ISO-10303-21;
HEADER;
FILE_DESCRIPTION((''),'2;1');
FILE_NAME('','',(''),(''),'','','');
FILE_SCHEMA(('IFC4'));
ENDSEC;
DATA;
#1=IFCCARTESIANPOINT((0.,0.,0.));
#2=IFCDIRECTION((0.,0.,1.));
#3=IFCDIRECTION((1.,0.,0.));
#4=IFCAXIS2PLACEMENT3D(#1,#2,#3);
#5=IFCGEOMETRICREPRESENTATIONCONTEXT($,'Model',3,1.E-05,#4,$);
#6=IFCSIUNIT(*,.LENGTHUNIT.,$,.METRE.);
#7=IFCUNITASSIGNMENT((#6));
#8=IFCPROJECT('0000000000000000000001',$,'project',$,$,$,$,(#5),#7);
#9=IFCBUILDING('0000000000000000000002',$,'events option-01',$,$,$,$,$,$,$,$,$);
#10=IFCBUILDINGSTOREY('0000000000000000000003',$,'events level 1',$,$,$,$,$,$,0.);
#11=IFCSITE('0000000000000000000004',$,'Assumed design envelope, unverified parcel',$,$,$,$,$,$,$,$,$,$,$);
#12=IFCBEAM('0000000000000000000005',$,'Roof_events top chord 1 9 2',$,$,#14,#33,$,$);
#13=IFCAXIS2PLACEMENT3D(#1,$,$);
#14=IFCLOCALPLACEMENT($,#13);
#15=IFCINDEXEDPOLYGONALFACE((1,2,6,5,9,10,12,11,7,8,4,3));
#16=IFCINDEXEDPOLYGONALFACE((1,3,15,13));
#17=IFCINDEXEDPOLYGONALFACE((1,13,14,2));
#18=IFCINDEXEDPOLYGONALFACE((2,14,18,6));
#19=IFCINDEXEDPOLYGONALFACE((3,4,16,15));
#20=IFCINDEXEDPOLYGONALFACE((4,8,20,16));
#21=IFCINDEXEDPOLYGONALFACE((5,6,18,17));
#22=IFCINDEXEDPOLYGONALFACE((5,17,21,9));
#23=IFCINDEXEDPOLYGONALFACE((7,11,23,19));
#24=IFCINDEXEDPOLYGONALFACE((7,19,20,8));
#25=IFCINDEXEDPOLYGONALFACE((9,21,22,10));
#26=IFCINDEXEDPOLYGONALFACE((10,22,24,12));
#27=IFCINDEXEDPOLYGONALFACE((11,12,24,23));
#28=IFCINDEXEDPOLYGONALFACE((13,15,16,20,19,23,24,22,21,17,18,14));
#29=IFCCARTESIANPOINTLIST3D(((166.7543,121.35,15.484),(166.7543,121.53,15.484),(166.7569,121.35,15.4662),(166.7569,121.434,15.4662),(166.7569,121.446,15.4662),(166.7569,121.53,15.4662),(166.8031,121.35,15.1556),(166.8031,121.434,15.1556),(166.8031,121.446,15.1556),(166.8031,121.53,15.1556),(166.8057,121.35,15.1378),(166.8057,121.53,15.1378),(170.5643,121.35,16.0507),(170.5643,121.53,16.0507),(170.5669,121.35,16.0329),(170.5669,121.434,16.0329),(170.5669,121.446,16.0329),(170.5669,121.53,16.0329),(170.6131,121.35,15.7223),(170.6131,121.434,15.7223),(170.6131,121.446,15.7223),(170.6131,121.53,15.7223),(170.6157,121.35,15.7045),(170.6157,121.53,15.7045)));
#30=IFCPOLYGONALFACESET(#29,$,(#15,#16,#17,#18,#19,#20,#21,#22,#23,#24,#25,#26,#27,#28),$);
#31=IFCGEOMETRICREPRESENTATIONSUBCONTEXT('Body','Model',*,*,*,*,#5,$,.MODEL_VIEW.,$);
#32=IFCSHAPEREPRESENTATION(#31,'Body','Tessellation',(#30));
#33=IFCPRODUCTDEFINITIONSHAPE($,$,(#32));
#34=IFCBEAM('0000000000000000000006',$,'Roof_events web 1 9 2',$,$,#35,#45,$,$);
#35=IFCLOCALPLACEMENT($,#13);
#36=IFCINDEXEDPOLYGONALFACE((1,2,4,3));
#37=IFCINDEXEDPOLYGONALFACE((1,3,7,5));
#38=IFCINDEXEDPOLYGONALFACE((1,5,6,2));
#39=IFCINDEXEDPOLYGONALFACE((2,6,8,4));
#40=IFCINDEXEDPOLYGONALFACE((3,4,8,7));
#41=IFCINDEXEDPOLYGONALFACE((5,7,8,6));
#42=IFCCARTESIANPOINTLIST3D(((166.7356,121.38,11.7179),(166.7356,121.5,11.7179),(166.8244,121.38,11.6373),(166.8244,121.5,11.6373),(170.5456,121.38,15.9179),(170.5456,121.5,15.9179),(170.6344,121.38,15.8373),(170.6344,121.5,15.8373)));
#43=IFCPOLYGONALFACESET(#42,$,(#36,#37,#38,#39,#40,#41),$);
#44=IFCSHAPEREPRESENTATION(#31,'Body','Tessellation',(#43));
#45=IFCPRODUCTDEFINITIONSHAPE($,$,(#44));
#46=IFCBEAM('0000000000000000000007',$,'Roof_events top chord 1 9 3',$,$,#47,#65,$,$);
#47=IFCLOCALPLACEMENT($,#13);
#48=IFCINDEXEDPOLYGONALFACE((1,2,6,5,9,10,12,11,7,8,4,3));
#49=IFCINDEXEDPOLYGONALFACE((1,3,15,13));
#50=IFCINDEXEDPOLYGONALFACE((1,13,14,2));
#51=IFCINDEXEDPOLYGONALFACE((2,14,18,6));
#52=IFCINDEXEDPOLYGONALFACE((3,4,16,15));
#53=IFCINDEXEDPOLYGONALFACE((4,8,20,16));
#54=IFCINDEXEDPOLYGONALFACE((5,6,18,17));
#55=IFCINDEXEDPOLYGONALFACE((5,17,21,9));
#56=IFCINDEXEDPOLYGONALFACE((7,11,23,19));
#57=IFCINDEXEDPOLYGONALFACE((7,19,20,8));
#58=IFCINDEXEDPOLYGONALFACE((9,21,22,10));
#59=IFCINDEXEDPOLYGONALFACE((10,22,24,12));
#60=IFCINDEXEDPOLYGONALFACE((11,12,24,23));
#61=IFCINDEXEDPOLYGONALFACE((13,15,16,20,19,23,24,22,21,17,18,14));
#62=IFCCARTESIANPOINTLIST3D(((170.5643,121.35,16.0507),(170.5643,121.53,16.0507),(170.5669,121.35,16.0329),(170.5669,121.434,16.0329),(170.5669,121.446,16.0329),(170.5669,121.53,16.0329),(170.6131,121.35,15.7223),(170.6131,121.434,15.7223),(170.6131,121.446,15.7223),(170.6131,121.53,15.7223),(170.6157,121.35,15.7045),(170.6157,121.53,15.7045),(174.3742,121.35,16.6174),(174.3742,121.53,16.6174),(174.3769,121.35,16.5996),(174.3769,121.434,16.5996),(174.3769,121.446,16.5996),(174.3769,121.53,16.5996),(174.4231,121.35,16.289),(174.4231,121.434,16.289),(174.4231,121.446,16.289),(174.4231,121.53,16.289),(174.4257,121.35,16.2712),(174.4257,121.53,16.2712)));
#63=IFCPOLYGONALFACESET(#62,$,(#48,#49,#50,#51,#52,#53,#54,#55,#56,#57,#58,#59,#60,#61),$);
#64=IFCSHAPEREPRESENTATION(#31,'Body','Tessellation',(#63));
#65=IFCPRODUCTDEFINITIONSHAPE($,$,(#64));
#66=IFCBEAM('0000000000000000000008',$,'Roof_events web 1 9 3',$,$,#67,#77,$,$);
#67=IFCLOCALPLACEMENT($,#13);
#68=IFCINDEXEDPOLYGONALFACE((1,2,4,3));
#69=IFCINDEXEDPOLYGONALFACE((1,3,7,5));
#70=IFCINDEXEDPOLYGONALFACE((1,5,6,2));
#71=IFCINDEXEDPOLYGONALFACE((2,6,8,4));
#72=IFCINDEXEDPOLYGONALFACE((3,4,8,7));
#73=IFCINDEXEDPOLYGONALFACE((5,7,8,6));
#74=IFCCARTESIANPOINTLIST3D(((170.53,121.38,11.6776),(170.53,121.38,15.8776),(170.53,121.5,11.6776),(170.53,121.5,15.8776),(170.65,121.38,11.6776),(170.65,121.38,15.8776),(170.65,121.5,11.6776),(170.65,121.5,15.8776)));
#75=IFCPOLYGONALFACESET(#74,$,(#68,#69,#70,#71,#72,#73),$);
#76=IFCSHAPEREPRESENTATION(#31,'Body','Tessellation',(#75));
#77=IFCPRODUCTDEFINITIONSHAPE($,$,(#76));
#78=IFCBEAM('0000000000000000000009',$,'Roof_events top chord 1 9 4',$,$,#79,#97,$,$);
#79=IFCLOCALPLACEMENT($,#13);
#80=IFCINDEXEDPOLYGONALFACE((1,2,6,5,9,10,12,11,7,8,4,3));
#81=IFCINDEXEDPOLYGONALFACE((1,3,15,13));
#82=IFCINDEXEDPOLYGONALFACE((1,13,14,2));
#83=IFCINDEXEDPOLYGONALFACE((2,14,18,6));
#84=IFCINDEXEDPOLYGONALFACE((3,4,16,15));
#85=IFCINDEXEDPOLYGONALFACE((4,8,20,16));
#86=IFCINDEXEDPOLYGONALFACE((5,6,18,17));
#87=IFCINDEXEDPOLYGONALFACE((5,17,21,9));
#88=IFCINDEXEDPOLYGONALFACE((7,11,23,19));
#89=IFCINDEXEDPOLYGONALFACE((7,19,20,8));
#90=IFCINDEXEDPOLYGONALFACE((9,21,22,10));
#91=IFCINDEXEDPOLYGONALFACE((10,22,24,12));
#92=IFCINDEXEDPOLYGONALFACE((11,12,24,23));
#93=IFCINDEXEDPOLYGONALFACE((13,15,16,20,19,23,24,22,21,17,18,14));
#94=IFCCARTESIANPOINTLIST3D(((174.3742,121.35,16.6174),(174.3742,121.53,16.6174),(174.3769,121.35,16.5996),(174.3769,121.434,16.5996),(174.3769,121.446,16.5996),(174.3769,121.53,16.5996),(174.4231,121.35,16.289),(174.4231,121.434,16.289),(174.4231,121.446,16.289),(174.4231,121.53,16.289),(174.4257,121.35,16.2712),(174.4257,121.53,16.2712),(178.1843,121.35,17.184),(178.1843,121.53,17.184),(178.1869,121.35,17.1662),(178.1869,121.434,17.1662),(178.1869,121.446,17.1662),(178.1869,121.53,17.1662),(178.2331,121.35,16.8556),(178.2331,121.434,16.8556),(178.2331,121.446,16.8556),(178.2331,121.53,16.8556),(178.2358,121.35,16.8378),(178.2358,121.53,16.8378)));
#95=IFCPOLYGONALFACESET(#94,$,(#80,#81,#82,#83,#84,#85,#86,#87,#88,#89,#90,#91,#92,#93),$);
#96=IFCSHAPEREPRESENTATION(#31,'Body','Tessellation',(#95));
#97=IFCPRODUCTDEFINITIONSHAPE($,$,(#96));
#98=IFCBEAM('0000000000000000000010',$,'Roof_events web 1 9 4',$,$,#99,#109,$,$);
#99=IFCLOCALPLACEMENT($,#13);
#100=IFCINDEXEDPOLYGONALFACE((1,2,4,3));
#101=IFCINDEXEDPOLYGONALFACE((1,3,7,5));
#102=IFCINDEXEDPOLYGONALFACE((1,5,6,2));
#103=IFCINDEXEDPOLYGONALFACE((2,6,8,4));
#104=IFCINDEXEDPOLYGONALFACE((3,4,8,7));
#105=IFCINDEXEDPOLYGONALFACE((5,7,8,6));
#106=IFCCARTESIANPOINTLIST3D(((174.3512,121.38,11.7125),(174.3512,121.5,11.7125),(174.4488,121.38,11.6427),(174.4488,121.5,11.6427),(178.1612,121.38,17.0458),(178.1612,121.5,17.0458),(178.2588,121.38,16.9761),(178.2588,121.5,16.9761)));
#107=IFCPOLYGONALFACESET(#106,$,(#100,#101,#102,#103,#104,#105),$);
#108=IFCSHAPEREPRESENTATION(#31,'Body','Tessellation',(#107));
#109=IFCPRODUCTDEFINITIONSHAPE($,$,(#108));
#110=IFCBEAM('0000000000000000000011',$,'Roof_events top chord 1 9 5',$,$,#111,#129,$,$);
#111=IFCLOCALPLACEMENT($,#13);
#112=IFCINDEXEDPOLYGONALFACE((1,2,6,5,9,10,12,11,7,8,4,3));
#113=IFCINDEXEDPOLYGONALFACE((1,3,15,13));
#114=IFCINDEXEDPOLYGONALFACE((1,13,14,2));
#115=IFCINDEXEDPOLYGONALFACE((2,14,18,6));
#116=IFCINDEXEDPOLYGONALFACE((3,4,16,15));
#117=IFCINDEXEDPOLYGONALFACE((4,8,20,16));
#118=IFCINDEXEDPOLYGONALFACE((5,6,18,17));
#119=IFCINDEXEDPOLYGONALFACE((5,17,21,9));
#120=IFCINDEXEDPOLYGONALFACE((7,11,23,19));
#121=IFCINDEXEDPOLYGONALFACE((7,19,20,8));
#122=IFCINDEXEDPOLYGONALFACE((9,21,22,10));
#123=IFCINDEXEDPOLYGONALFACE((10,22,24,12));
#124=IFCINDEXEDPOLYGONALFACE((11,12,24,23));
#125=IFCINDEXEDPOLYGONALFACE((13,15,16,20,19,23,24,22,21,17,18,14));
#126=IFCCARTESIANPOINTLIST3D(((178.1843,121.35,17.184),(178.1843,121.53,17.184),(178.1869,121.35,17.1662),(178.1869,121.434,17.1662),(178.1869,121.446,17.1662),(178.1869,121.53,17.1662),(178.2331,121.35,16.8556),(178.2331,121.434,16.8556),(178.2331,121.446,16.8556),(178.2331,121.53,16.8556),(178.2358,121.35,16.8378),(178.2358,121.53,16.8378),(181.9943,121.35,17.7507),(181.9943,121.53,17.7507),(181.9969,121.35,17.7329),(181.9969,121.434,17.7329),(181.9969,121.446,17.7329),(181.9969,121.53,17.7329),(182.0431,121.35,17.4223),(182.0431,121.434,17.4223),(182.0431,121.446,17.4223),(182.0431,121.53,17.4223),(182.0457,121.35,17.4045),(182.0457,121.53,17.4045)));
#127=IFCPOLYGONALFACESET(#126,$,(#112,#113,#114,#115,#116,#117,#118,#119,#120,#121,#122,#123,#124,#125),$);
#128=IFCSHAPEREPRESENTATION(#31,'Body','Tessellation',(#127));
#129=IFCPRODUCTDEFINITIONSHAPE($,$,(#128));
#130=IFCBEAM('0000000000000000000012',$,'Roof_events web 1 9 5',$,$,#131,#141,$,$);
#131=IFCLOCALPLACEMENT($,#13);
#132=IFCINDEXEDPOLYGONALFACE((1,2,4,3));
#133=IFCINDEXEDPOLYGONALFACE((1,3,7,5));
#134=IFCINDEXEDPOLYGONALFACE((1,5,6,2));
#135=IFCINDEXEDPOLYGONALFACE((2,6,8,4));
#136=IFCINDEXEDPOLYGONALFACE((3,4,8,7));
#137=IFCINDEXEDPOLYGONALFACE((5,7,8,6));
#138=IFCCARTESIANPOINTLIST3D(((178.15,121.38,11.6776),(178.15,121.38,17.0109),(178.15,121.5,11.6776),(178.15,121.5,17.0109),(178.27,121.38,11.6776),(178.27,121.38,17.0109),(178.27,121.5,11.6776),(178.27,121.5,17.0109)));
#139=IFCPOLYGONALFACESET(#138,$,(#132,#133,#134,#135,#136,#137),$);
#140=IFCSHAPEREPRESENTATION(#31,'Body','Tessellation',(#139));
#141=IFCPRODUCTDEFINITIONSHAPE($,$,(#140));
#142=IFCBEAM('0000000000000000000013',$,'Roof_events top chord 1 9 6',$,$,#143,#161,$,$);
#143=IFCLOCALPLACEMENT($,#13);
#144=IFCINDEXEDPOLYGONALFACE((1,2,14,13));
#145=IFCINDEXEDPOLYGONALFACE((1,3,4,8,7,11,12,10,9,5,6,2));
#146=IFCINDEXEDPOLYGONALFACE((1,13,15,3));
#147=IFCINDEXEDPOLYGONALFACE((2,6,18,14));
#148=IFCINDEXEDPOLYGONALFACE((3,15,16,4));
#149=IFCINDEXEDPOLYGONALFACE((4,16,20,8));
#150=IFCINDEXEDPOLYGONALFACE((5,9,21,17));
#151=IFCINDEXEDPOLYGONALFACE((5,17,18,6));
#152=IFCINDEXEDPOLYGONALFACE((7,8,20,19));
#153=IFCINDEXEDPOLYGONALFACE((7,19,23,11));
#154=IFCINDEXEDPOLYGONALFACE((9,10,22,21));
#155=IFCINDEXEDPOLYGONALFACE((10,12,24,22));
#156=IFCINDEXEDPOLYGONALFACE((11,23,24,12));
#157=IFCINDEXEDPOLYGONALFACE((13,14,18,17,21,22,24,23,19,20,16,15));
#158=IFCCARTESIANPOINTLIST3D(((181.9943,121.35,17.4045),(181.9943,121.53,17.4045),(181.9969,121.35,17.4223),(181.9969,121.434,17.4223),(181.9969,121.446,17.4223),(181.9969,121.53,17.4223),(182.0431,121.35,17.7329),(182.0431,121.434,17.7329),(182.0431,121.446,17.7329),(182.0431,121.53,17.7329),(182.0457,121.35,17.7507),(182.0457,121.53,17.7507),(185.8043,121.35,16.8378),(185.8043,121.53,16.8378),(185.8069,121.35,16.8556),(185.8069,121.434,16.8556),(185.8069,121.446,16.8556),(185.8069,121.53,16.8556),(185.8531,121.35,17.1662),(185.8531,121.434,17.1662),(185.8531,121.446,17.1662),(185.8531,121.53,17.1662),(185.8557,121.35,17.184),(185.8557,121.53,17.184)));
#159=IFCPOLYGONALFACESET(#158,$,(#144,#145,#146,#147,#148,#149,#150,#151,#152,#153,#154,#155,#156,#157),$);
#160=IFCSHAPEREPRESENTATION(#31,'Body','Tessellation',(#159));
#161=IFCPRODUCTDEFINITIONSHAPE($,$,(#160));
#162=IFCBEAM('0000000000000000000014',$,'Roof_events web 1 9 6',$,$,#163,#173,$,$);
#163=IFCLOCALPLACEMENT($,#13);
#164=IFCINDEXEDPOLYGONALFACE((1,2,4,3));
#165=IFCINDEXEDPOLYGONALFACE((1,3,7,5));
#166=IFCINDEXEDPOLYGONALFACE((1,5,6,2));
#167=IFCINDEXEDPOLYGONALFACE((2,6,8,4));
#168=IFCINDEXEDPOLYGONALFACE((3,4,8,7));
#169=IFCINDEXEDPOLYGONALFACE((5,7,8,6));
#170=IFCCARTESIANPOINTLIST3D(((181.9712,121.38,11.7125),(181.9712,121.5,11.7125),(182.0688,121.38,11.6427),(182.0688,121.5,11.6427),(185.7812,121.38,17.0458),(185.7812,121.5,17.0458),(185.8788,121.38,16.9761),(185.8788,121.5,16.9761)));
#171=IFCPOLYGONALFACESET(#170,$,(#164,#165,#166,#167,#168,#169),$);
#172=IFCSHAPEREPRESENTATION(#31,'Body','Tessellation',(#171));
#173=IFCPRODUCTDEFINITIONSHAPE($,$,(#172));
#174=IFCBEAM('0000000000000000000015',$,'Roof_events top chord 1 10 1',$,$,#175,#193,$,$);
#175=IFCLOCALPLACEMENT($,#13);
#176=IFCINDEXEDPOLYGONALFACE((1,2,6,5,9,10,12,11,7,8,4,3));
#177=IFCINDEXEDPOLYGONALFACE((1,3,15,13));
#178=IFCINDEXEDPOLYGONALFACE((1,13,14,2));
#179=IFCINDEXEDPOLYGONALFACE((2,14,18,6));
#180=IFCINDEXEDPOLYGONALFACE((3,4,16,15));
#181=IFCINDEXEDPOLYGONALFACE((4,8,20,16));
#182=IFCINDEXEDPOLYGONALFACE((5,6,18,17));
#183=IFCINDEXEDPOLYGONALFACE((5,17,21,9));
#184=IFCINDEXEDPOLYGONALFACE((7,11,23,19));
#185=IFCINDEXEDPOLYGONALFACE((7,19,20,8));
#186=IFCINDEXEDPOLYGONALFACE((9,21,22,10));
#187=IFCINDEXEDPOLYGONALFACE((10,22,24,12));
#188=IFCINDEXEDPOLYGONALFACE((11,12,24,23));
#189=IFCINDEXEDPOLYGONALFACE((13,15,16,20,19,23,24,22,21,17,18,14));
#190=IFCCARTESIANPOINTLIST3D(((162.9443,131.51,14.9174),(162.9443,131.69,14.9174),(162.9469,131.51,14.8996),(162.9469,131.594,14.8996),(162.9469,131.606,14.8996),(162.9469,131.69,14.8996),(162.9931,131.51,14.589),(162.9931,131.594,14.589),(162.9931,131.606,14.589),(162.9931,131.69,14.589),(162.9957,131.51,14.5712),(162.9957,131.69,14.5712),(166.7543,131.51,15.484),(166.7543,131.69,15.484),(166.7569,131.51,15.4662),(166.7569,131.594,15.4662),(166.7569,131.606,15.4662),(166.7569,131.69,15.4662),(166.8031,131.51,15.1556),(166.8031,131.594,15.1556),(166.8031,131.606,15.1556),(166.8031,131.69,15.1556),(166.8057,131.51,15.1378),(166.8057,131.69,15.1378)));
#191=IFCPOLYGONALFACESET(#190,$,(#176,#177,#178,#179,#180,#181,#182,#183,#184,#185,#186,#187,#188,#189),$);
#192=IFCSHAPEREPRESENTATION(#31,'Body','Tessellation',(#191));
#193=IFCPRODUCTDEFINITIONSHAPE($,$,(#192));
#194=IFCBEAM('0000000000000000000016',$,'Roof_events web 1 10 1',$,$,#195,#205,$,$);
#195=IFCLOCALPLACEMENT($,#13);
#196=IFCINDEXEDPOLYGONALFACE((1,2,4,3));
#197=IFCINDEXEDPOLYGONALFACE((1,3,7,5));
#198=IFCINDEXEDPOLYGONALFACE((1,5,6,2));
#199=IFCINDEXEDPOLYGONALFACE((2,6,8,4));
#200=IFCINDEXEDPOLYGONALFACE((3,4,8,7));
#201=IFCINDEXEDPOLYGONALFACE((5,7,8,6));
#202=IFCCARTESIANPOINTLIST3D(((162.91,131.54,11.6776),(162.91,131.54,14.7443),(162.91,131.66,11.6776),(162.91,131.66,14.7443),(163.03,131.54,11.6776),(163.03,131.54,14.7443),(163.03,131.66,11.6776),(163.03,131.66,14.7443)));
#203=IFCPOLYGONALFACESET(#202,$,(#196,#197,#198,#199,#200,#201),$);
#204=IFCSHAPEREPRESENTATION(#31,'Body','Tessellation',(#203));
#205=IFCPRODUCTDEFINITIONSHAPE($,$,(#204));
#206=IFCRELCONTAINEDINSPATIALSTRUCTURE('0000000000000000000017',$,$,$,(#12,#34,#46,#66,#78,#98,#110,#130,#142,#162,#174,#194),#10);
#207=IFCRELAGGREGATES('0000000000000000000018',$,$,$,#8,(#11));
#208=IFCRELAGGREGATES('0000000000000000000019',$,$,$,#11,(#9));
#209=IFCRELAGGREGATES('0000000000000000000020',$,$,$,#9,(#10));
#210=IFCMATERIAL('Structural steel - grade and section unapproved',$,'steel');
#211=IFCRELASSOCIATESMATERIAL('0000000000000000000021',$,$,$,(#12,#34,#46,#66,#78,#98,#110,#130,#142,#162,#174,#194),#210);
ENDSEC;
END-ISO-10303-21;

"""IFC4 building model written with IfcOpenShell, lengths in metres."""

from ifc_helpers import new_model, si_unit, frame, origin_with_axes, place, context, subcontext, project, spatial, rectangle, i_section, extrude, material, element, save


model = new_model("IFC4")

# Units and contexts
model_context = context("Model", 3, precision=1e-05, world=origin_with_axes())
body_context = subcontext(model_context, "Body", "Model", "MODEL_VIEW")
ifc_project = project(units=[si_unit("LENGTHUNIT", "METRE")], contexts=[model_context])

# Site, building, storey
site = spatial("IfcSite", under=ifc_project, Name="Assumed design envelope, unverified parcel")
building = spatial("IfcBuilding", under=site, Name="events option-01")
storey = spatial("IfcBuildingStorey", under=building, Name="events level 1", Elevation=0.0)

# Beams
ifc_material_1 = material(Name="Structural steel - grade and section unapproved", Category="steel")
beam_1_placement = place(None, frame((166.78, 121.44, 15.3109), z_axis=(0.98912, 0.0, 0.147113), x_axis=(0.0, 1.0, 0.0)))
element("IfcBeam", 1, at=beam_1_placement, inside=storey, material=ifc_material_1, Name="Roof_events top chord 1 9 2", context=body_context, shape_type="SweptSolid", body=[
    extrude(i_section(OverallWidth=0.18, OverallDepth=0.35, WebThickness=0.012, FlangeThickness=0.018, FilletRadius=0.0), origin_with_axes(), (0.0, 0.0, 1.0), 3.8519),
])
beam_2_placement = place(None, frame((166.78, 121.44, 11.6776), z_axis=(0.671882, 0.0, 0.740658), x_axis=(0.0, 1.0, 0.0)))
element("IfcBeam", 2, at=beam_2_placement, inside=storey, material=ifc_material_1, Name="Roof_events web 1 9 2", context=body_context, shape_type="SweptSolid", body=[
    extrude(rectangle(XDim=0.12, YDim=0.12), origin_with_axes(), (0.0, 0.0, 1.0), 5.6706),
])
beam_3_placement = place(None, frame((170.59, 121.44, 15.8776), z_axis=(0.98912, 0.0, 0.147113), x_axis=(0.0, 1.0, 0.0)))
element("IfcBeam", 3, at=beam_3_placement, inside=storey, material=ifc_material_1, Name="Roof_events top chord 1 9 3", context=body_context, shape_type="SweptSolid", body=[
    extrude(i_section(OverallWidth=0.18, OverallDepth=0.35, WebThickness=0.012, FlangeThickness=0.018, FilletRadius=0.0), origin_with_axes(), (0.0, 0.0, 1.0), 3.8519),
])
beam_4_placement = place(None, frame((170.59, 121.44, 11.6776), z_axis=(0.0, 0.0, 1.0), x_axis=(-1.0, 0.0, 0.0)))
element("IfcBeam", 4, at=beam_4_placement, inside=storey, material=ifc_material_1, Name="Roof_events web 1 9 3", context=body_context, shape_type="SweptSolid", body=[
    extrude(rectangle(XDim=0.12, YDim=0.12), origin_with_axes(), (0.0, 0.0, 1.0), 4.2),
])
beam_5_placement = place(None, frame((174.4, 121.44, 16.4443), z_axis=(0.98912, 0.0, 0.147112), x_axis=(0.0, 1.0, 0.0)))
element("IfcBeam", 5, at=beam_5_placement, inside=storey, material=ifc_material_1, Name="Roof_events top chord 1 9 4", context=body_context, shape_type="SweptSolid", body=[
    extrude(i_section(OverallWidth=0.18, OverallDepth=0.35, WebThickness=0.012, FlangeThickness=0.018, FilletRadius=0.0), origin_with_axes(), (0.0, 0.0, 1.0), 3.8519),
])
beam_6_placement = place(None, frame((174.4, 121.44, 11.6776), z_axis=(0.581288, 0.0, 0.813698), x_axis=(0.0, 1.0, 0.0)))
element("IfcBeam", 6, at=beam_6_placement, inside=storey, material=ifc_material_1, Name="Roof_events web 1 9 4", context=body_context, shape_type="SweptSolid", body=[
    extrude(rectangle(XDim=0.12, YDim=0.12), origin_with_axes(), (0.0, 0.0, 1.0), 6.5544),
])
beam_7_placement = place(None, frame((178.21, 121.44, 17.0109), z_axis=(0.98912, 0.0, 0.147113), x_axis=(0.0, 1.0, 0.0)))
element("IfcBeam", 7, at=beam_7_placement, inside=storey, material=ifc_material_1, Name="Roof_events top chord 1 9 5", context=body_context, shape_type="SweptSolid", body=[
    extrude(i_section(OverallWidth=0.18, OverallDepth=0.35, WebThickness=0.012, FlangeThickness=0.018, FilletRadius=0.0), origin_with_axes(), (0.0, 0.0, 1.0), 3.8519),
])
beam_8_placement = place(None, frame((178.21, 121.44, 11.6776), z_axis=(0.0, 0.0, 1.0), x_axis=(-1.0, 0.0, 0.0)))
element("IfcBeam", 8, at=beam_8_placement, inside=storey, material=ifc_material_1, Name="Roof_events web 1 9 5", context=body_context, shape_type="SweptSolid", body=[
    extrude(rectangle(XDim=0.12, YDim=0.12), origin_with_axes(), (0.0, 0.0, 1.0), 5.3333),
])
beam_9_placement = place(None, frame((182.02, 121.44, 17.5776), z_axis=(0.98912, 0.0, -0.147113), x_axis=(0.0, 1.0, 0.0)))
element("IfcBeam", 9, at=beam_9_placement, inside=storey, material=ifc_material_1, Name="Roof_events top chord 1 9 6", context=body_context, shape_type="SweptSolid", body=[
    extrude(i_section(OverallWidth=0.18, OverallDepth=0.35, WebThickness=0.012, FlangeThickness=0.018, FilletRadius=0.0), origin_with_axes(), (0.0, 0.0, 1.0), 3.8519),
])
beam_10_placement = place(None, frame((182.02, 121.44, 11.6776), z_axis=(0.581286, 0.0, 0.813699), x_axis=(0.0, 1.0, 0.0)))
element("IfcBeam", 10, at=beam_10_placement, inside=storey, material=ifc_material_1, Name="Roof_events web 1 9 6", context=body_context, shape_type="SweptSolid", body=[
    extrude(rectangle(XDim=0.12, YDim=0.12), origin_with_axes(), (0.0, 0.0, 1.0), 6.5544),
])
beam_11_placement = place(None, frame((162.97, 131.6, 14.7443), z_axis=(0.98912, 0.0, 0.147113), x_axis=(0.0, 1.0, 0.0)))
element("IfcBeam", 11, at=beam_11_placement, inside=storey, material=ifc_material_1, Name="Roof_events top chord 1 10 1", context=body_context, shape_type="SweptSolid", body=[
    extrude(i_section(OverallWidth=0.18, OverallDepth=0.35, WebThickness=0.012, FlangeThickness=0.018, FilletRadius=0.0), origin_with_axes(), (0.0, 0.0, 1.0), 3.8519),
])
beam_12_placement = place(None, frame((162.97, 131.6, 11.6776), z_axis=(0.0, 0.0, 1.0), x_axis=(-1.0, 0.0, 0.0)))
element("IfcBeam", 12, at=beam_12_placement, inside=storey, material=ifc_material_1, Name="Roof_events web 1 10 1", context=body_context, shape_type="SweptSolid", body=[
    extrude(rectangle(XDim=0.12, YDim=0.12), origin_with_axes(), (0.0, 0.0, 1.0), 3.0667),
])

save(model, "model.ifc")
